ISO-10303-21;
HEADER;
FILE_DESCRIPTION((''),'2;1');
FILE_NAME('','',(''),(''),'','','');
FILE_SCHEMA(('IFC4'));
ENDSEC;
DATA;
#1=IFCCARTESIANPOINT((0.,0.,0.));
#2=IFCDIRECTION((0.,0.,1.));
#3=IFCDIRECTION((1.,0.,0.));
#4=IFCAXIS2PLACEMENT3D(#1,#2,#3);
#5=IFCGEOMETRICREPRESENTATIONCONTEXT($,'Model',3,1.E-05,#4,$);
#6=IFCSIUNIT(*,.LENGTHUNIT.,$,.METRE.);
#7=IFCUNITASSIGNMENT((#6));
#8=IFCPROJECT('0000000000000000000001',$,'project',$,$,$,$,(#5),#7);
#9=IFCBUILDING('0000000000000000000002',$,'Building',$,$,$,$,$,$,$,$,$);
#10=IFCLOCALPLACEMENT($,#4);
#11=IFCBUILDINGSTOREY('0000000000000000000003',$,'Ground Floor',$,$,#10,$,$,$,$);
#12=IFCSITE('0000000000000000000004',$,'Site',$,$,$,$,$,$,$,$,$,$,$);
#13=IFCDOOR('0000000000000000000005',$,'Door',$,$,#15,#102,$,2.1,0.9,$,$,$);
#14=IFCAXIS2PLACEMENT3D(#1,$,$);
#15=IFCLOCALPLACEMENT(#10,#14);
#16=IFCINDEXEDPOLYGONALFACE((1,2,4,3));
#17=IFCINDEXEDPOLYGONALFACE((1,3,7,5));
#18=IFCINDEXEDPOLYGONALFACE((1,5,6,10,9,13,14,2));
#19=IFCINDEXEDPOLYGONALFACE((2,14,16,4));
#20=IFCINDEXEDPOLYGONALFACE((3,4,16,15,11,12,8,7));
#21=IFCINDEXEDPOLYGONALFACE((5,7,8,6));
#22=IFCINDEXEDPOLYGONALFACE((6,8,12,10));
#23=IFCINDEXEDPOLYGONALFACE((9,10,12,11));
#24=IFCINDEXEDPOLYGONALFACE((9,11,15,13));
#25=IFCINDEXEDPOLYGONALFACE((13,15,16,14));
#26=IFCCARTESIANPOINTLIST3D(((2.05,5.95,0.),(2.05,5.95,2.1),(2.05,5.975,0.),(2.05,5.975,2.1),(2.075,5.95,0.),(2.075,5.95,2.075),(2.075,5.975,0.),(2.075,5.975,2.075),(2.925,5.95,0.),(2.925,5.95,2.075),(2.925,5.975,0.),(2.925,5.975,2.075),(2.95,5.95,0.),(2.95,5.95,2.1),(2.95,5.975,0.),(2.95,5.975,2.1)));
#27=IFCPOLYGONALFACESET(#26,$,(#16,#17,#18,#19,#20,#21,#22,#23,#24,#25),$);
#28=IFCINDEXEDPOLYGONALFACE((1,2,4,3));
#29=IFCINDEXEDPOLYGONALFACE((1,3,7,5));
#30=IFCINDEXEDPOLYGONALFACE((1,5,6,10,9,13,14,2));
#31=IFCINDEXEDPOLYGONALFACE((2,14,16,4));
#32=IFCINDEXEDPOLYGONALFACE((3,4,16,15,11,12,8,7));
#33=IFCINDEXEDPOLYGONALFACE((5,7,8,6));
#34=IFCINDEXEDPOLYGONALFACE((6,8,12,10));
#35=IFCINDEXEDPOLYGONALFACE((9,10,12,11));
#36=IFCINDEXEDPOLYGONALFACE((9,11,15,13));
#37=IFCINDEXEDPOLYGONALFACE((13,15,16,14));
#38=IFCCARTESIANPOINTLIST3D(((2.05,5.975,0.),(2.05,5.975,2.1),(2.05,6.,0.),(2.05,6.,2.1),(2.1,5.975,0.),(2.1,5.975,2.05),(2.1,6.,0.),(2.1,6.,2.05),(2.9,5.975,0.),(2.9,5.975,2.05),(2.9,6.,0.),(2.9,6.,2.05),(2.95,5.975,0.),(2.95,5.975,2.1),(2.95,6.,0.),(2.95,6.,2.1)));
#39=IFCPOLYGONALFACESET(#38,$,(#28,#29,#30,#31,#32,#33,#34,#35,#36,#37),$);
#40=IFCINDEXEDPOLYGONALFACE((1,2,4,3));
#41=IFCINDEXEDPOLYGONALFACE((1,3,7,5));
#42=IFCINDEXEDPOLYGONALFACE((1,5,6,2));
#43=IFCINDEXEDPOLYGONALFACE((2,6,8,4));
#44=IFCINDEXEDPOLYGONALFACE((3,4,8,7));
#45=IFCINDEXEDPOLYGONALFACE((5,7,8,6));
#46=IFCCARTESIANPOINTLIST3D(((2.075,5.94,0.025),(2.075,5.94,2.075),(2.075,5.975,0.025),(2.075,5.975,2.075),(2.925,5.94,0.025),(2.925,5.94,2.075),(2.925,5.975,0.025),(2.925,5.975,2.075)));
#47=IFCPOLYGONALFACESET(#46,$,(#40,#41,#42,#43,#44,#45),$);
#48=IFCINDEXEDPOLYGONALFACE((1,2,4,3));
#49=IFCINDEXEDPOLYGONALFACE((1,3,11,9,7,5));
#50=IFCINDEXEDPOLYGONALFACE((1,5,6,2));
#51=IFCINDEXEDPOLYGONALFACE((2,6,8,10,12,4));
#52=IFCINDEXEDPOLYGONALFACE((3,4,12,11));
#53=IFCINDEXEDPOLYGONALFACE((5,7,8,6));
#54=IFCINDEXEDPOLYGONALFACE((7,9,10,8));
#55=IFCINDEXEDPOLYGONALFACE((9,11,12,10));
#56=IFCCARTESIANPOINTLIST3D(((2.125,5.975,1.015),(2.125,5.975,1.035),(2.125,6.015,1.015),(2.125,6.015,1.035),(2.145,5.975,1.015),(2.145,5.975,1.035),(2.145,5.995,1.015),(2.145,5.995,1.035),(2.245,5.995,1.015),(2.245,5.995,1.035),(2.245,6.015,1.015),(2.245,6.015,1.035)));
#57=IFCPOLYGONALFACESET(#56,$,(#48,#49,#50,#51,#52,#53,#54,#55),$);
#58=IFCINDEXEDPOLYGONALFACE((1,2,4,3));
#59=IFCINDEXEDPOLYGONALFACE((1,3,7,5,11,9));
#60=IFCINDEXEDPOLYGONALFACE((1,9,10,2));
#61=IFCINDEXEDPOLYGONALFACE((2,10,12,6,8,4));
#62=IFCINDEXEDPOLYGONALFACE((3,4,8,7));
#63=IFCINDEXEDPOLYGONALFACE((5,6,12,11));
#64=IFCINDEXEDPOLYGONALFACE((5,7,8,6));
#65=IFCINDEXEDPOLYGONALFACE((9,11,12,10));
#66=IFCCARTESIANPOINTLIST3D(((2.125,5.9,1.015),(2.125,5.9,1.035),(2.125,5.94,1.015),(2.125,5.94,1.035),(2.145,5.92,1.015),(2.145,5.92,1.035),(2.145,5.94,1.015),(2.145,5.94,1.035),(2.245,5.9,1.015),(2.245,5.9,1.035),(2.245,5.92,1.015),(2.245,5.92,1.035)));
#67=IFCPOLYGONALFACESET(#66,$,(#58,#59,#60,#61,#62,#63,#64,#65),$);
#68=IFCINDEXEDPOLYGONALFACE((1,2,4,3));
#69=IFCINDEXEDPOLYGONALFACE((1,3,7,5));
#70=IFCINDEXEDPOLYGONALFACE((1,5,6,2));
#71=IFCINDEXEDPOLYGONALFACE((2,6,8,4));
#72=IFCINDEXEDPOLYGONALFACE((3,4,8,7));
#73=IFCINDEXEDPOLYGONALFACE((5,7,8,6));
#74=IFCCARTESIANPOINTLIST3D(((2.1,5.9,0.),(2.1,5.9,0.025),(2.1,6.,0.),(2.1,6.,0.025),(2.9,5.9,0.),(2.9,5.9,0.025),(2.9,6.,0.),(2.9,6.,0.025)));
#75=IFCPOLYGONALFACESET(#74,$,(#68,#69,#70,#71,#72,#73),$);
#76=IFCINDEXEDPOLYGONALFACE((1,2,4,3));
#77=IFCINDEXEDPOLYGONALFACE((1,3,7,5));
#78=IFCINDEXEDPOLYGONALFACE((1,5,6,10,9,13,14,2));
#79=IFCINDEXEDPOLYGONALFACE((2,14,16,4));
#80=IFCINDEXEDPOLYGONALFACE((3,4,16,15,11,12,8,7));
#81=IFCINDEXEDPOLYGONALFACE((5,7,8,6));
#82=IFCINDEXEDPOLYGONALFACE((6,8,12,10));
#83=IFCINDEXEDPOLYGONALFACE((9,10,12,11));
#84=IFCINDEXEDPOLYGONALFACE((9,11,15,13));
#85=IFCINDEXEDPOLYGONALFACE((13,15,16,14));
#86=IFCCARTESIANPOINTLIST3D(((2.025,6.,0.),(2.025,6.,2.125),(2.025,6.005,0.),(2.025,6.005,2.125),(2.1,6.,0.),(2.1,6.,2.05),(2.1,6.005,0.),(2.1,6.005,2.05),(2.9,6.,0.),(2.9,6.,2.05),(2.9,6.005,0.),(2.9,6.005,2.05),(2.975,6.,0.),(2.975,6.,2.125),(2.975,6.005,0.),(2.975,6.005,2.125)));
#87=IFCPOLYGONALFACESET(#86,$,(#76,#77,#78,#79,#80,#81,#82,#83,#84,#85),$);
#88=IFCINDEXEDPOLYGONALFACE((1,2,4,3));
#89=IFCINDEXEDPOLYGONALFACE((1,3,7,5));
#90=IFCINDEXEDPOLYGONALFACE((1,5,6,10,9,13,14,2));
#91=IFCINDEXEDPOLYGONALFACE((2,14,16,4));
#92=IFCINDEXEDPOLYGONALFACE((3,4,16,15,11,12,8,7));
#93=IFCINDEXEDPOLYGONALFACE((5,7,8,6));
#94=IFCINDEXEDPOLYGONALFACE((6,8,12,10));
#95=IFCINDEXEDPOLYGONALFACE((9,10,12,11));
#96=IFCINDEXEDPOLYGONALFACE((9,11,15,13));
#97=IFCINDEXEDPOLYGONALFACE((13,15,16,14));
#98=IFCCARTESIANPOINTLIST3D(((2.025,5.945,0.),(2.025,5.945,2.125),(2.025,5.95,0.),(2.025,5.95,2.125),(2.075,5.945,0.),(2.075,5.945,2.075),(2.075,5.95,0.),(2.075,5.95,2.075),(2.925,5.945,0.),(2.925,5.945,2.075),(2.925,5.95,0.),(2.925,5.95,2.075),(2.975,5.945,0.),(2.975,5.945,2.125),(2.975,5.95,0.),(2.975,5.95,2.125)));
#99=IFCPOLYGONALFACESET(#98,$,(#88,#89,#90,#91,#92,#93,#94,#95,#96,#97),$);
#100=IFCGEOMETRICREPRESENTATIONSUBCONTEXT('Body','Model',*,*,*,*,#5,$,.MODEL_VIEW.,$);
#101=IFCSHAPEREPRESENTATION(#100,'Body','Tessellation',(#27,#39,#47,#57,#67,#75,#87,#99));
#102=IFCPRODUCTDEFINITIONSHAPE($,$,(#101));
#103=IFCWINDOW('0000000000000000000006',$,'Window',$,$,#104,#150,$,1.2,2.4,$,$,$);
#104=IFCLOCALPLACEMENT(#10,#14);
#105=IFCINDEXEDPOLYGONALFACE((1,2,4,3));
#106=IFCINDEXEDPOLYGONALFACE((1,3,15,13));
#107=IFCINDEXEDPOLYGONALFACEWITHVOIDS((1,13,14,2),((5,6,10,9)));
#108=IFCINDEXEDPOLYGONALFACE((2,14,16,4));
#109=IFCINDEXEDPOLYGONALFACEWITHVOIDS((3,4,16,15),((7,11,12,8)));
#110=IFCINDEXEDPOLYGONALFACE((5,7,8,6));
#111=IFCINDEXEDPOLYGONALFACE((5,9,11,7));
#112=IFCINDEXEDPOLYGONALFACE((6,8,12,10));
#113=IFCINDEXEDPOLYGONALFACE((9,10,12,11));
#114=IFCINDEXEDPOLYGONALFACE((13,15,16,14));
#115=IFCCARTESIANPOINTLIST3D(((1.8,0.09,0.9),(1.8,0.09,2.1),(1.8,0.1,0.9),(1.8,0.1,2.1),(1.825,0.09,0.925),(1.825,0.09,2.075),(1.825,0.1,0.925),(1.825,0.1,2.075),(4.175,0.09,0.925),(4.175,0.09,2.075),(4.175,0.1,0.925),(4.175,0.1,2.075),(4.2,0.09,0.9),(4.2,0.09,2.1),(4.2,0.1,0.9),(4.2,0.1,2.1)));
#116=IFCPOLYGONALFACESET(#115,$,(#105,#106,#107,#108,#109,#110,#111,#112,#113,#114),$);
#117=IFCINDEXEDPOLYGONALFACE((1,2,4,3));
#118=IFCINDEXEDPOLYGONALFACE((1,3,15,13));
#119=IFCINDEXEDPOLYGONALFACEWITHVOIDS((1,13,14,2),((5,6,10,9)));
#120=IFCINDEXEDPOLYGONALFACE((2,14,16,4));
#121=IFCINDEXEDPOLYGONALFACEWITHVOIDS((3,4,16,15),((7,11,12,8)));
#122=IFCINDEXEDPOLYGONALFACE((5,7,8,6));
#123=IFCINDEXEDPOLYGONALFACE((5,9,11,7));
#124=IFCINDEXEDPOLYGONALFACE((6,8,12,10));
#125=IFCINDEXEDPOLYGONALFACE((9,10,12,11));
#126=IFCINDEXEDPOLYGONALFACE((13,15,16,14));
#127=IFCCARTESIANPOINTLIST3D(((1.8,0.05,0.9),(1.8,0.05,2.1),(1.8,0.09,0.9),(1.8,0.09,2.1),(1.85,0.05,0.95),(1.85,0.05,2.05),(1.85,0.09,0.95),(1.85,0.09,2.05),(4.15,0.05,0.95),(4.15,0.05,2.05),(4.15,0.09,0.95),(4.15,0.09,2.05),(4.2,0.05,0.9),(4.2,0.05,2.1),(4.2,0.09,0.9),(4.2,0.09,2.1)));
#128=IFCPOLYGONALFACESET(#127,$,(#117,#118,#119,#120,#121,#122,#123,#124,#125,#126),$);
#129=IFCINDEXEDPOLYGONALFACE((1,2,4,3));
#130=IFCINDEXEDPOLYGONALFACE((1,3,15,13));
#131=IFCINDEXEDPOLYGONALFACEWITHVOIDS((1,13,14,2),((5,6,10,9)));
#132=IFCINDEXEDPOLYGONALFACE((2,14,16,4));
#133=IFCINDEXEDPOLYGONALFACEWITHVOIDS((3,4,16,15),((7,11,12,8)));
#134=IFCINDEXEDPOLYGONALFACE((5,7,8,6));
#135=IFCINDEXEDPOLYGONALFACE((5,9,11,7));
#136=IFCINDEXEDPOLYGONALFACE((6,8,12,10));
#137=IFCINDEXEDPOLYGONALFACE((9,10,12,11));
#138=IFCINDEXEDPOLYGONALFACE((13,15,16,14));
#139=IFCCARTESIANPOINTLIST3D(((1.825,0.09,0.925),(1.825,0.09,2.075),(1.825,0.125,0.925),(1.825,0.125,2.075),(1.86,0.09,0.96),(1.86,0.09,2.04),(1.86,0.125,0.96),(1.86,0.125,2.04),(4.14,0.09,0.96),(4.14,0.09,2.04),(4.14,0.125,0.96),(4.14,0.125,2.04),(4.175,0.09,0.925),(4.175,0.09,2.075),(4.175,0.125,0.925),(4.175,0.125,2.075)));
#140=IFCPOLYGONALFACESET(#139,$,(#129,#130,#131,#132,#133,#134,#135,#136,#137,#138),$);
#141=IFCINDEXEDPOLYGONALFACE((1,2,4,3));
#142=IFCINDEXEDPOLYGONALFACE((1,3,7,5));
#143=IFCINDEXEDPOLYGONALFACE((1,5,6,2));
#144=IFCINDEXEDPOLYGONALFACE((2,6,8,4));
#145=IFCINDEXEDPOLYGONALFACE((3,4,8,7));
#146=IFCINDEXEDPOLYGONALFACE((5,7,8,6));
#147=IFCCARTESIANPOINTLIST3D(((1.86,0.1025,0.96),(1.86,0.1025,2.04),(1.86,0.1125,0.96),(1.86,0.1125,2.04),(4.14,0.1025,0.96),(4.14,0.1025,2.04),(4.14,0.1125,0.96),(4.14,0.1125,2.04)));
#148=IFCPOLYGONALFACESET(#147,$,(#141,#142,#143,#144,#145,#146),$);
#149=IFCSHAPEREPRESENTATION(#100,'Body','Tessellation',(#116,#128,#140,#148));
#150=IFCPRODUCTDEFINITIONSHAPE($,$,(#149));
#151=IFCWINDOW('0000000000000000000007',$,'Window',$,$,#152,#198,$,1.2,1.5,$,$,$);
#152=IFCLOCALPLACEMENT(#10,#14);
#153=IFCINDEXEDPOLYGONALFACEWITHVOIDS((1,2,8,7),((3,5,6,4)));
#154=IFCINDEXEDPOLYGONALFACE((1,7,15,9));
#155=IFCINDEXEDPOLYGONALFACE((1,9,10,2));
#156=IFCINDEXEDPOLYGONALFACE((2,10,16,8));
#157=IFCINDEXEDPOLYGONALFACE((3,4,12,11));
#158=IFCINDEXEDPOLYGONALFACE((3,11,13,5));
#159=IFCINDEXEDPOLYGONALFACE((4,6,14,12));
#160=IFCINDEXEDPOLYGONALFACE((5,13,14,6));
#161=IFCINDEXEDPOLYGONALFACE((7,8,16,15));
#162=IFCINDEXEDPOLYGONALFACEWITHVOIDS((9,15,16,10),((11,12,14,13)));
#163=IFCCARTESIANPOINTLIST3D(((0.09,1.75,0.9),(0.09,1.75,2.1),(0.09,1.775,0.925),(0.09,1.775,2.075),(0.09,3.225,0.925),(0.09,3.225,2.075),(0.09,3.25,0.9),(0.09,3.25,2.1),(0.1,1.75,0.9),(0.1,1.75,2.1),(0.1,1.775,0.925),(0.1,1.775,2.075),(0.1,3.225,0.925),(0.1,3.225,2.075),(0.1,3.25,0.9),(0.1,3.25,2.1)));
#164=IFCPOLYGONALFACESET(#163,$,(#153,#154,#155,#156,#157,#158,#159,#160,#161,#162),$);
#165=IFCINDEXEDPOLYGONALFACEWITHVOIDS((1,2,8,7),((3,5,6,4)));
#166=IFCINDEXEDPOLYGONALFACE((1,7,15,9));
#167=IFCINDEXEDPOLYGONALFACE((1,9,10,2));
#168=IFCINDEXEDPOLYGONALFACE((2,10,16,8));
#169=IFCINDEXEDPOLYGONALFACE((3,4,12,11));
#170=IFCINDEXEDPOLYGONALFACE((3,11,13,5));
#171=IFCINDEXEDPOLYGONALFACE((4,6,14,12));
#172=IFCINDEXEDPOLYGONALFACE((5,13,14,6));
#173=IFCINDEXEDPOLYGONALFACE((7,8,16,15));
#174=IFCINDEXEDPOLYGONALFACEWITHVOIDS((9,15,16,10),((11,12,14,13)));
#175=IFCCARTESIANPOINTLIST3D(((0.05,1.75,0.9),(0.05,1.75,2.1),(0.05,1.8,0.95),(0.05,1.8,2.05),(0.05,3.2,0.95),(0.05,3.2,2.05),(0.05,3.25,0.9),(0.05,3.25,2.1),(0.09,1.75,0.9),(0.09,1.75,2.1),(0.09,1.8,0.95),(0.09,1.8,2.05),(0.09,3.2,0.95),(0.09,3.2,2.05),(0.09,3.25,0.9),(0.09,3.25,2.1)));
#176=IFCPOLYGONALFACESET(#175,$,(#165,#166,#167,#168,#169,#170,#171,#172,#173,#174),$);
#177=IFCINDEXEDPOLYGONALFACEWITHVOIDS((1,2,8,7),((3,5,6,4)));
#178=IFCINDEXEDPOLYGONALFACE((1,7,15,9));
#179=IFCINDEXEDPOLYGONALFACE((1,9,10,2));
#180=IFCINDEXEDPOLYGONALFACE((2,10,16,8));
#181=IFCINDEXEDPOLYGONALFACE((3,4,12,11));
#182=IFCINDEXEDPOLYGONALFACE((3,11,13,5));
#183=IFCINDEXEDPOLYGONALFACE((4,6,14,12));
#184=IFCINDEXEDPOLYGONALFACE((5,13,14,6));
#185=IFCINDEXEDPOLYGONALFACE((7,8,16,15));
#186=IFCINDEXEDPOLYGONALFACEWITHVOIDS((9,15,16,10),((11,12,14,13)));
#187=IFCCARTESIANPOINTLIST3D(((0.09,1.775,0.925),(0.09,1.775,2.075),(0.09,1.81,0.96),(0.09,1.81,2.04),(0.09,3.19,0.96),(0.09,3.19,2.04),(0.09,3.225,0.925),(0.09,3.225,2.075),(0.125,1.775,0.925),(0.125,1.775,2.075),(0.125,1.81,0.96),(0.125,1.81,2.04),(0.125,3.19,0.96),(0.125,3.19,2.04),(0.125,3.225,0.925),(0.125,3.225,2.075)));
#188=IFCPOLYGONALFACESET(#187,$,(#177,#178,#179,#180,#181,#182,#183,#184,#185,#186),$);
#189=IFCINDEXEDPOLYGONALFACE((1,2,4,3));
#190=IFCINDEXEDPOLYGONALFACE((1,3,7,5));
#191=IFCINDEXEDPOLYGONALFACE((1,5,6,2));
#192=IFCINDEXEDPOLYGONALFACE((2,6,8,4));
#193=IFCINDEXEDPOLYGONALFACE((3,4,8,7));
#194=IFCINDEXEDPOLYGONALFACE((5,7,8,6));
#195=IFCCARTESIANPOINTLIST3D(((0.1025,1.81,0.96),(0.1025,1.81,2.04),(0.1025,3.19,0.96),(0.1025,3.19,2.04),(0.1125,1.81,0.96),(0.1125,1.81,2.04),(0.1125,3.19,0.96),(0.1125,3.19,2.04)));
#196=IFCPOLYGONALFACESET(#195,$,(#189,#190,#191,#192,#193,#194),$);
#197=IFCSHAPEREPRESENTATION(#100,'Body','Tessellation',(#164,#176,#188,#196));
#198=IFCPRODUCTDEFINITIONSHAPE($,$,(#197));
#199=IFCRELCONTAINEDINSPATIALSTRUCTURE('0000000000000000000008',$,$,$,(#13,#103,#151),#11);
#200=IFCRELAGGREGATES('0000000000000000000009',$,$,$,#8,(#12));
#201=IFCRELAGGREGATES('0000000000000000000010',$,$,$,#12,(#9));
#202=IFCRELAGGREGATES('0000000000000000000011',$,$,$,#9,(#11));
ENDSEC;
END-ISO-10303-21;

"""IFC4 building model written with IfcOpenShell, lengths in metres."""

from ifc_helpers import new_model, si_unit, frame, origin_with_axes, place, context, subcontext, project, spatial, line, indexed_curve, outline, extrude, element, save


model = new_model("IFC4")

# Units and contexts
model_context = context("Model", 3, precision=1e-05, world=origin_with_axes())
body_context = subcontext(model_context, "Body", "Model", "MODEL_VIEW")
ifc_project = project(units=[si_unit("LENGTHUNIT", "METRE")], contexts=[model_context])

# Site, building, storey
site = spatial("IfcSite", under=ifc_project, Name="Site")
building = spatial("IfcBuilding", under=site, Name="Building")
storey_placement = place(None, origin_with_axes())
storey = spatial("IfcBuildingStorey", under=building, at=storey_placement, Name="Ground Floor")

# Door
door_1_placement = place(storey_placement, frame((2.95, 6.0, 0.0), z_axis=(0.0, 0.0, 1.0), x_axis=(-1.0, 0.0, 0.0)))
element("IfcDoor", 1, at=door_1_placement, inside=storey, Name="Door", OverallHeight=2.1, OverallWidth=0.9, context=body_context, shape_type="SweptSolid", body=[
    extrude(outline(indexed_curve([(0.0, 0.0), (0.0, 2.1), (0.9, 2.1), (0.9, 0.0), (0.875, 0.0), (0.875, 2.075), (0.025, 2.075), (0.025, 0.0)], segments=[line(1, 2, 3, 4, 5, 6, 7, 8, 1)])), frame((0.0, 0.025, 0.0), z_axis=(0.0, -1.0, 0.0), x_axis=(1.0, 0.0, 0.0)), (0.0, 0.0, -1.0), 0.025),
    extrude(outline(indexed_curve([(0.0, 0.0), (0.0, 2.1), (0.9, 2.1), (0.9, 0.0), (0.85, 0.0), (0.85, 2.05), (0.05, 2.05), (0.05, 0.0)], segments=[line(1, 2, 3, 4, 5, 6, 7, 8, 1)])), frame((0.0, 0.0, 0.0), z_axis=(0.0, -1.0, 0.0), x_axis=(1.0, 0.0, 0.0)), (0.0, 0.0, -1.0), 0.025),
    extrude(outline(indexed_curve([(0.0, 0.0), (0.85, 0.0), (0.85, 0.035), (0.0, 0.035)], segments=[line(1, 2, 3, 4, 1)])), frame((0.025, 0.025, 0.025), z_axis=(0.0, 0.0, 1.0), x_axis=(1.0, 0.0, 0.0)), (0.0, 0.0, 1.0), 2.05),
    extrude(outline(indexed_curve([(0.0, 0.0), (0.0, -0.04), (-0.12, -0.04), (-0.12, -0.02), (-0.02, -0.02), (-0.02, 0.0)], segments=[line(1, 2, 3, 4, 5, 6, 1)])), frame((0.825, 0.025, 1.015), z_axis=(0.0, 0.0, 1.0), x_axis=(1.0, 0.0, 0.0)), (0.0, 0.0, 1.0), 0.02),
    extrude(outline(indexed_curve([(0.0, 0.0), (0.0, 0.04), (-0.12, 0.04), (-0.12, 0.02), (-0.02, 0.02), (-0.02, 0.0)], segments=[line(1, 2, 3, 4, 5, 6, 1)])), frame((0.825, 0.06, 1.015), z_axis=(0.0, 0.0, 1.0), x_axis=(1.0, 0.0, 0.0)), (0.0, 0.0, 1.0), 0.02),
    extrude(outline(indexed_curve([(0.0, 0.0), (0.8, 0.0), (0.8, 0.1), (0.0, 0.1)], segments=[line(1, 2, 3, 4, 1)])), frame((0.05, 0.0, 0.0), z_axis=(0.0, 0.0, 1.0), x_axis=(1.0, 0.0, 0.0)), (0.0, 0.0, 1.0), 0.025),
    extrude(outline(indexed_curve([(0.0, 0.0), (0.0, 2.125), (0.95, 2.125), (0.95, 0.0), (0.875, 0.0), (0.875, 2.05), (0.075, 2.05), (0.075, 0.0)], segments=[line(1, 2, 3, 4, 5, 6, 7, 8, 1)])), frame((-0.025, -0.005, 0.0), z_axis=(0.0, -1.0, 0.0), x_axis=(1.0, 0.0, 0.0)), (0.0, 0.0, -1.0), 0.005),
    extrude(outline(indexed_curve([(0.0, 0.0), (0.0, 2.125), (0.95, 2.125), (0.95, 0.0), (0.9, 0.0), (0.9, 2.075), (0.05, 2.075), (0.05, 0.0)], segments=[line(1, 2, 3, 4, 5, 6, 7, 8, 1)])), frame((-0.025, 0.05, 0.0), z_axis=(0.0, -1.0, 0.0), x_axis=(1.0, 0.0, 0.0)), (0.0, 0.0, -1.0), 0.005),
])

# Windows
window_placement = place(storey_placement, frame((1.8, 0.0, 0.9), z_axis=(0.0, 0.0, 1.0), x_axis=(1.0, 0.0, 0.0)))
element("IfcWindow", 2, at=window_placement, inside=storey, Name="Window", OverallHeight=1.2, OverallWidth=2.4, context=body_context, shape_type="SweptSolid", body=[
    extrude(outline(indexed_curve([(0.0, 0.0), (2.4, 0.0), (2.4, 1.2), (0.0, 1.2)], segments=[line(1, 2, 3, 4, 1)]), holes=[indexed_curve([(0.025, 0.025), (2.375, 0.025), (2.375, 1.175), (0.025, 1.175)], segments=[line(1, 2, 3, 4, 1)])]), frame((0.0, 0.09, 0.0), z_axis=(0.0, -1.0, 0.0), x_axis=(1.0, 0.0, 0.0)), (0.0, 0.0, -1.0), 0.01),
    extrude(outline(indexed_curve([(0.0, 0.0), (2.4, 0.0), (2.4, 1.2), (0.0, 1.2)], segments=[line(1, 2, 3, 4, 1)]), holes=[indexed_curve([(0.05, 0.05), (2.35, 0.05), (2.35, 1.15), (0.05, 1.15)], segments=[line(1, 2, 3, 4, 1)])]), frame((0.0, 0.05, 0.0), z_axis=(0.0, -1.0, 0.0), x_axis=(1.0, 0.0, 0.0)), (0.0, 0.0, -1.0), 0.04),
    extrude(outline(indexed_curve([(0.0, 0.0), (2.35, 0.0), (2.35, 1.15), (0.0, 1.15)], segments=[line(1, 2, 3, 4, 1)]), holes=[indexed_curve([(0.035, 0.035), (2.315, 0.035), (2.315, 1.115), (0.035, 1.115)], segments=[line(1, 2, 3, 4, 1)])]), frame((0.025, 0.09, 0.025), z_axis=(0.0, -1.0, 0.0), x_axis=(1.0, 0.0, 0.0)), (0.0, 0.0, -1.0), 0.035),
    extrude(outline(indexed_curve([(0.035, 0.035), (2.315, 0.035), (2.315, 1.115), (0.035, 1.115)], segments=[line(1, 2, 3, 4, 1)])), frame((0.025, 0.1025, 0.025), z_axis=(0.0, -1.0, 0.0), x_axis=(1.0, 0.0, 0.0)), (0.0, 0.0, -1.0), 0.01),
])
for number, where, z_axis, x_axis, name in (
    (3, (0.0, 3.25, 0.9), (0.0, 0.0, 1.0), (0.0, -1.0, 0.0), "Window"),
):
    element("IfcWindow", number, at=place(storey_placement, frame(where, z_axis=z_axis, x_axis=x_axis)), inside=storey, Name=name, OverallHeight=1.2, OverallWidth=1.5, context=body_context, shape_type="SweptSolid", body=[
        extrude(outline(indexed_curve([(0.0, 0.0), (1.5, 0.0), (1.5, 1.2), (0.0, 1.2)], segments=[line(1, 2, 3, 4, 1)]), holes=[indexed_curve([(0.025, 0.025), (1.475, 0.025), (1.475, 1.175), (0.025, 1.175)], segments=[line(1, 2, 3, 4, 1)])]), frame((0.0, 0.09, 0.0), z_axis=(0.0, -1.0, 0.0), x_axis=(1.0, 0.0, 0.0)), (0.0, 0.0, -1.0), 0.01),
        extrude(outline(indexed_curve([(0.0, 0.0), (1.5, 0.0), (1.5, 1.2), (0.0, 1.2)], segments=[line(1, 2, 3, 4, 1)]), holes=[indexed_curve([(0.05, 0.05), (1.45, 0.05), (1.45, 1.15), (0.05, 1.15)], segments=[line(1, 2, 3, 4, 1)])]), frame((0.0, 0.05, 0.0), z_axis=(0.0, -1.0, 0.0), x_axis=(1.0, 0.0, 0.0)), (0.0, 0.0, -1.0), 0.04),
        extrude(outline(indexed_curve([(0.0, 0.0), (1.45, 0.0), (1.45, 1.15), (0.0, 1.15)], segments=[line(1, 2, 3, 4, 1)]), holes=[indexed_curve([(0.035, 0.035), (1.415, 0.035), (1.415, 1.115), (0.035, 1.115)], segments=[line(1, 2, 3, 4, 1)])]), frame((0.025, 0.09, 0.025), z_axis=(0.0, -1.0, 0.0), x_axis=(1.0, 0.0, 0.0)), (0.0, 0.0, -1.0), 0.035),
        extrude(outline(indexed_curve([(0.035, 0.035), (1.415, 0.035), (1.415, 1.115), (0.035, 1.115)], segments=[line(1, 2, 3, 4, 1)])), frame((0.025, 0.1025, 0.025), z_axis=(0.0, -1.0, 0.0), x_axis=(1.0, 0.0, 0.0)), (0.0, 0.0, -1.0), 0.01),
    ])

save(model, "model.ifc")
